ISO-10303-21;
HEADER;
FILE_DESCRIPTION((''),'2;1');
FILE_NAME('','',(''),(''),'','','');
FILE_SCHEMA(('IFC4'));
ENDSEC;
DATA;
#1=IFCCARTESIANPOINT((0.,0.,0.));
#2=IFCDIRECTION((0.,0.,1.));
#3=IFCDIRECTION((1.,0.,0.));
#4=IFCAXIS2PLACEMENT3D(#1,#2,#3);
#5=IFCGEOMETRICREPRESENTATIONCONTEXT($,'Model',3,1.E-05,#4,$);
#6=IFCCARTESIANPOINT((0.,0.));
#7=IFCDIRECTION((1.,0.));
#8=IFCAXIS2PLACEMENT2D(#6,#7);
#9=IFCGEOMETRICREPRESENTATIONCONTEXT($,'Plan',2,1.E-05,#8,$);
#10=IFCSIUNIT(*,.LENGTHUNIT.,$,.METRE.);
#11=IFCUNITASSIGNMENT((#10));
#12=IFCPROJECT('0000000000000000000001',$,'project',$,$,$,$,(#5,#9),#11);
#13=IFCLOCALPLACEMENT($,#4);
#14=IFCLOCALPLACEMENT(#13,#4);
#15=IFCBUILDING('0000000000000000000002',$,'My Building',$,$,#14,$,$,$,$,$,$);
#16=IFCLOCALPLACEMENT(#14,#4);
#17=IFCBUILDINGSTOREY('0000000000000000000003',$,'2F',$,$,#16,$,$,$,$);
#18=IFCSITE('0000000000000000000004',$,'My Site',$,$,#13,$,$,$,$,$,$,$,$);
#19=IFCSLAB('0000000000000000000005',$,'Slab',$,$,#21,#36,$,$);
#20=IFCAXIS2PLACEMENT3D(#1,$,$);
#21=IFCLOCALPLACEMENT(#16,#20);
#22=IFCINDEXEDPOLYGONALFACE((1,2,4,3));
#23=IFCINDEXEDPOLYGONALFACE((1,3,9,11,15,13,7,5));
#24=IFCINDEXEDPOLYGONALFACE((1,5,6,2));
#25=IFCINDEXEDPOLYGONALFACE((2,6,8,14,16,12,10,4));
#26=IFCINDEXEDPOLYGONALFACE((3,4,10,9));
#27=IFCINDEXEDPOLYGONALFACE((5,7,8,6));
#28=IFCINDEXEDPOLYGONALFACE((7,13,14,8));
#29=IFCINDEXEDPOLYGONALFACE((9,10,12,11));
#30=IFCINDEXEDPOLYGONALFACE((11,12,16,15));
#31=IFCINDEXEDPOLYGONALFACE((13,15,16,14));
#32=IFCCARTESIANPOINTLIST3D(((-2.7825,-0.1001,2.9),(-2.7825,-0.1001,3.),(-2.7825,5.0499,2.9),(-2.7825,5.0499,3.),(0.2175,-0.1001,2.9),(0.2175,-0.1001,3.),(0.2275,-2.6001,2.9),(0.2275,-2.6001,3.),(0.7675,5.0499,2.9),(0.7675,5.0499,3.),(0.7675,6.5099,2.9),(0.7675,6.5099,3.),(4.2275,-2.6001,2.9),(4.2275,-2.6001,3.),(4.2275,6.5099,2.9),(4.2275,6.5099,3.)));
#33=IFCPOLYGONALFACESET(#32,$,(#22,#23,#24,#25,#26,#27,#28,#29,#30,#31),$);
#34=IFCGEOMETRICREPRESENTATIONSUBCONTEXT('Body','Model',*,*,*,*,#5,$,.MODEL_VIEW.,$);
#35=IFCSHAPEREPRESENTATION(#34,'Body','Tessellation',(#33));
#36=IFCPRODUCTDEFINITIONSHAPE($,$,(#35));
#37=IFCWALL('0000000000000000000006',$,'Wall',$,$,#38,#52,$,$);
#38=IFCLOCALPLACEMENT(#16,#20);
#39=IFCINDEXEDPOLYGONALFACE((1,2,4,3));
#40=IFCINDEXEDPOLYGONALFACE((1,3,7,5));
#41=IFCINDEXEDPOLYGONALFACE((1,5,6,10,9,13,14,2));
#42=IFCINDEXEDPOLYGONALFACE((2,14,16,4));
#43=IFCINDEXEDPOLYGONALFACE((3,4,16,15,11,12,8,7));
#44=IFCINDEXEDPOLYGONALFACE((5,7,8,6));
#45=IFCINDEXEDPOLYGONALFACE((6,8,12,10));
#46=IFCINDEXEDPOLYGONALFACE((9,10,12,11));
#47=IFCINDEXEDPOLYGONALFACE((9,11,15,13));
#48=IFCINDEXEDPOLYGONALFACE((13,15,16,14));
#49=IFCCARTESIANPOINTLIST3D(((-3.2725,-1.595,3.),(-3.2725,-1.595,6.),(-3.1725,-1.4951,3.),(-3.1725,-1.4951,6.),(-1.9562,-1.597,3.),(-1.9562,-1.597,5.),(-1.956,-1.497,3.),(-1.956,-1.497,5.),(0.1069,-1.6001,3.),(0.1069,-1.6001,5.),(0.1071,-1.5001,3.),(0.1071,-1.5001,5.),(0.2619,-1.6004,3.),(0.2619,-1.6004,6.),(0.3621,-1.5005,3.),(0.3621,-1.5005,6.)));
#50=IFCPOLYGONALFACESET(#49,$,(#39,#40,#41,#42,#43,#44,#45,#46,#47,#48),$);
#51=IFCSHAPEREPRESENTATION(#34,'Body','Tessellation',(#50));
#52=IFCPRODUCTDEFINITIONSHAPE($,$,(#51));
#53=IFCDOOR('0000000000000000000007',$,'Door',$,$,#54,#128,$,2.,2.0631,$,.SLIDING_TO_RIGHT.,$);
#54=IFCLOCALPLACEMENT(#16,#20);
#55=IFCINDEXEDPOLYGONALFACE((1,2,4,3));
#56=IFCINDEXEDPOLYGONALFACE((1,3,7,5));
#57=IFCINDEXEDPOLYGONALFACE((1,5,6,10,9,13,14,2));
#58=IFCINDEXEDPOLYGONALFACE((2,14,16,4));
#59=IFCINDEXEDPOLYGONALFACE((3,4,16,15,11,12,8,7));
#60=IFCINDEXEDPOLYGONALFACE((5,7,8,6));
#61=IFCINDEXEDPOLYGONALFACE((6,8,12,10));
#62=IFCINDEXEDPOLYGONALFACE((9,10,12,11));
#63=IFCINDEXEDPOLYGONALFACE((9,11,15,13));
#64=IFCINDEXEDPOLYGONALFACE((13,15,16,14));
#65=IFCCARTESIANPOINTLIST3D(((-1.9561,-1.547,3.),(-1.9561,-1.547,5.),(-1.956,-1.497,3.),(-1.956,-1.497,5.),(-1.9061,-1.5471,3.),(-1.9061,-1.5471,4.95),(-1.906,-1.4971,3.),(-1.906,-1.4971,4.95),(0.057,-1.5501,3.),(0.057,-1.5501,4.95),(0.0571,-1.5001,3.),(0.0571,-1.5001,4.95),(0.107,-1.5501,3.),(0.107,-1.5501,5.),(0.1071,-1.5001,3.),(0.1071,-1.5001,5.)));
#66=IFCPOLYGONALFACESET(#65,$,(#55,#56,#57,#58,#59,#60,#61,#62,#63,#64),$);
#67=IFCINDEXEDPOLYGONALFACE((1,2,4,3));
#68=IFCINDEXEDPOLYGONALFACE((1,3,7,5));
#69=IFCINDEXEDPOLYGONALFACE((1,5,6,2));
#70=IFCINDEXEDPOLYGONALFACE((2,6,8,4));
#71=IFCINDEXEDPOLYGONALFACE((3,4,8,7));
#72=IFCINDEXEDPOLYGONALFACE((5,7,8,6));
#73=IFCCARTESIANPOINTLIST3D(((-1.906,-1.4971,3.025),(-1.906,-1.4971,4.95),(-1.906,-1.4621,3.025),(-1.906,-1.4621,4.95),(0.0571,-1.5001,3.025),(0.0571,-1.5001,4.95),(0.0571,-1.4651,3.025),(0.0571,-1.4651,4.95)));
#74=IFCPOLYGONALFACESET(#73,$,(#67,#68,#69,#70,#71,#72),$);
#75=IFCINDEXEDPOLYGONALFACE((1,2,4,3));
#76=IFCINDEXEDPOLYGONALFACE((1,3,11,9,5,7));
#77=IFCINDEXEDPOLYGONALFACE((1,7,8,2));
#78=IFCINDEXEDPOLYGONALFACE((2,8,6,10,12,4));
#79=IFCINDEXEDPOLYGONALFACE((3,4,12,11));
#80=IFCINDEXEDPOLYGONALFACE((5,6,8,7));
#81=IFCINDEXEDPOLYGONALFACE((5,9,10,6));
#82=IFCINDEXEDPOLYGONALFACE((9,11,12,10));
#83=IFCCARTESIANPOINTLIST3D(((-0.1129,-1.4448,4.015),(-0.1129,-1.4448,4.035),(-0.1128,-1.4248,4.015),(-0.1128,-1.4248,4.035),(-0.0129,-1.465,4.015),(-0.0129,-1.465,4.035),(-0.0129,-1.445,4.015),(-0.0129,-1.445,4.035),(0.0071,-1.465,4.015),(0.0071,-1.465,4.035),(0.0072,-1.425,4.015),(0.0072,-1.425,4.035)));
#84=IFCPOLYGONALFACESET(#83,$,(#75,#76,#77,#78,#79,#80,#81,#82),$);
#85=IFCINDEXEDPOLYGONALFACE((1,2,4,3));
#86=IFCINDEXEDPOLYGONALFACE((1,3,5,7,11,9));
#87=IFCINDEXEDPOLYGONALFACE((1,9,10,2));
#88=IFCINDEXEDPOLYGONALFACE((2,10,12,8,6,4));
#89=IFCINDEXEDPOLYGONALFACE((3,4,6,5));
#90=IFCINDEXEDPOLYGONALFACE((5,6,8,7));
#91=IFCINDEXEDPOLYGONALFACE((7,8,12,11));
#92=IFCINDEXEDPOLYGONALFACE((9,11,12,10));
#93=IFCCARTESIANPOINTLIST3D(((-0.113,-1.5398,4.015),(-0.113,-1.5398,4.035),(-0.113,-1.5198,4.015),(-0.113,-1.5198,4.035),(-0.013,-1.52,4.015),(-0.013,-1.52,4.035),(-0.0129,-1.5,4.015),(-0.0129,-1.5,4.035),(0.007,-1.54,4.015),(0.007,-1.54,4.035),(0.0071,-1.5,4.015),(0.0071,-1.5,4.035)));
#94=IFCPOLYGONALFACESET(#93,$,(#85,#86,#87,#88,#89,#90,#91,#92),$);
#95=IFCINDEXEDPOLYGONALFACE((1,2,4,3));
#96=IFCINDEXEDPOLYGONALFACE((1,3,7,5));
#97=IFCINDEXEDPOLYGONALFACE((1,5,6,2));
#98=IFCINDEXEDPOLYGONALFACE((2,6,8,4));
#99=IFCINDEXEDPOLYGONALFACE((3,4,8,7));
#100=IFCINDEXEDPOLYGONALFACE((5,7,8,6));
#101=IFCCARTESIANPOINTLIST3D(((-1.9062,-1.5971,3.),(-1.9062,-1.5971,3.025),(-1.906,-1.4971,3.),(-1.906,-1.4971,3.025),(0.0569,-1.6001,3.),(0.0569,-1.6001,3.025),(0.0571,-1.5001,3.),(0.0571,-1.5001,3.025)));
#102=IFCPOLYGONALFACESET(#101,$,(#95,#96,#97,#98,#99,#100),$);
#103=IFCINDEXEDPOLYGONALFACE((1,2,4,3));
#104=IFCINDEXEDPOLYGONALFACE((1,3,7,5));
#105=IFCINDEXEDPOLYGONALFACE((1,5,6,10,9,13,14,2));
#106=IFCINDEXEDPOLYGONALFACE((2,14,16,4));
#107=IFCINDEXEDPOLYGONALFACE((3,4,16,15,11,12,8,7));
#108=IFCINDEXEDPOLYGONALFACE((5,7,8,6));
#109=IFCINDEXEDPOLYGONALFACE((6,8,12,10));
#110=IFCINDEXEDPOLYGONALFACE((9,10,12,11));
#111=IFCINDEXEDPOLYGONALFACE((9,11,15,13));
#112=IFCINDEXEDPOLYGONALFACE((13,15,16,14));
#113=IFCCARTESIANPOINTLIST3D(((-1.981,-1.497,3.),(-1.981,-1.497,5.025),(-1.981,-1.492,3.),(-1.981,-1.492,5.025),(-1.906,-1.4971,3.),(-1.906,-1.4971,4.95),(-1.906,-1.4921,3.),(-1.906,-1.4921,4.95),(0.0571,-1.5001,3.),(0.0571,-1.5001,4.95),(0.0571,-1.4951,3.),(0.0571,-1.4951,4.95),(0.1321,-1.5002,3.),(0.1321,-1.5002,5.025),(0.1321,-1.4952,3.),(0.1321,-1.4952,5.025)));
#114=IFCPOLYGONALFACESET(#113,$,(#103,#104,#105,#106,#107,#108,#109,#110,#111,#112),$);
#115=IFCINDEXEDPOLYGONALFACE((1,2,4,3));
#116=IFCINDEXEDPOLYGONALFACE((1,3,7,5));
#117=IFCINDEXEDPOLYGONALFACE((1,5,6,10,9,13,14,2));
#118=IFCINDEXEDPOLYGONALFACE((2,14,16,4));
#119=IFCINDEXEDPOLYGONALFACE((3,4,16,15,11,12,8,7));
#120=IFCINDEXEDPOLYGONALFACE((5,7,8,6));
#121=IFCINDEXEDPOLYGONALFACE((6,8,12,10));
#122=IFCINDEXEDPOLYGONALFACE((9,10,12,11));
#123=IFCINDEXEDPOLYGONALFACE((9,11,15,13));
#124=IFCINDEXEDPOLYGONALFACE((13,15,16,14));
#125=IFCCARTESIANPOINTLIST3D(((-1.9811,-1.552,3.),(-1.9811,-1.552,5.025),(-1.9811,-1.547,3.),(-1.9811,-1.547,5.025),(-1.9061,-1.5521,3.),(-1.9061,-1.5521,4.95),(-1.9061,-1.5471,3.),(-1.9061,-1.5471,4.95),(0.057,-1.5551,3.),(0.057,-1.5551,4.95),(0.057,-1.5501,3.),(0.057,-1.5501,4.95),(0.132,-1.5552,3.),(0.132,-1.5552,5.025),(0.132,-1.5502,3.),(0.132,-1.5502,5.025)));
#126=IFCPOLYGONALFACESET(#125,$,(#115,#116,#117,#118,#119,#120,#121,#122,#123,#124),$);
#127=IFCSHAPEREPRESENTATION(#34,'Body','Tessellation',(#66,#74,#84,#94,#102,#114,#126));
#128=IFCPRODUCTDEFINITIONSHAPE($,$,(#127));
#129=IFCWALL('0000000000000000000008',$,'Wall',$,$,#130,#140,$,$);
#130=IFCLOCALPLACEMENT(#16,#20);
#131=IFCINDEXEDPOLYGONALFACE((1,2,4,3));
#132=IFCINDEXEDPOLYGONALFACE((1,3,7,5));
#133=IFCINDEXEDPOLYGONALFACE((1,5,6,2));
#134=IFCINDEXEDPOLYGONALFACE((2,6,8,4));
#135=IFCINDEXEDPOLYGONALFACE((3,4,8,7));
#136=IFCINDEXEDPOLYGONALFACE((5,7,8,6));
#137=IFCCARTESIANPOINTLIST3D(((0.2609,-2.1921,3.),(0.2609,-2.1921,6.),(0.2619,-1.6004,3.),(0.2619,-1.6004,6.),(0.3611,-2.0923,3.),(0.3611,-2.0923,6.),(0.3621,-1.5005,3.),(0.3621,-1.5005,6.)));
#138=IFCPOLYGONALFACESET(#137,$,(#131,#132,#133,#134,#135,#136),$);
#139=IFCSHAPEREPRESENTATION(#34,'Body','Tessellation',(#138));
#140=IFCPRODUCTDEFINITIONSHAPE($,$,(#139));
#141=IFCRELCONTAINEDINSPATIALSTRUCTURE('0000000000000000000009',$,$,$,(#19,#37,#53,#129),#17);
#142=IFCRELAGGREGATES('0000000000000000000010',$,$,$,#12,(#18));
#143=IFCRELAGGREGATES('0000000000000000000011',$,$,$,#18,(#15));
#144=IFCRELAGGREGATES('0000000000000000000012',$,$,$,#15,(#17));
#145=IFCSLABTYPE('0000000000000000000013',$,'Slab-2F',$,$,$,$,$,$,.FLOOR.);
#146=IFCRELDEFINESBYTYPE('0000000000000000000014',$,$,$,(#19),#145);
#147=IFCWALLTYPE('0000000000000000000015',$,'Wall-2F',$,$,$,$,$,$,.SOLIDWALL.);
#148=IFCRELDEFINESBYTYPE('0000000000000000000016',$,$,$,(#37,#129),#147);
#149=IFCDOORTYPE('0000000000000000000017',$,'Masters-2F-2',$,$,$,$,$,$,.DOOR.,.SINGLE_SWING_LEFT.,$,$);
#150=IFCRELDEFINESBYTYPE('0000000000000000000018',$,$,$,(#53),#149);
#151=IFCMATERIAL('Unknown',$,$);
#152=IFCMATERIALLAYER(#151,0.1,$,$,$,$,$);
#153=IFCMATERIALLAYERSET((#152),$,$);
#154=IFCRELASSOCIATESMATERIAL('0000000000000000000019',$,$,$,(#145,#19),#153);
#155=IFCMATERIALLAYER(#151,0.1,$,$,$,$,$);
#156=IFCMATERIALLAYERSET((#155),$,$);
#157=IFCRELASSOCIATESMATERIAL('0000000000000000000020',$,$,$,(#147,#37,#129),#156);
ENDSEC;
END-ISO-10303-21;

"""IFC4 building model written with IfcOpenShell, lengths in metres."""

from ifc_helpers import new_model, entity, si_unit, frame, origin_with_axes, origin_2d_with_axis, place, context, subcontext, project, spatial, line, indexed_curve, outline, extrude, shape, source, transform, mapped, material, layer, layer_set, layer_usage, type_object, type_shapes, element, fill, save


model = new_model("IFC4")

# Units and contexts
model_context = context("Model", 3, precision=1e-05, world=origin_with_axes())
plan_context = context("Plan", 2, precision=1e-05, world=origin_2d_with_axis())
body_context_1 = subcontext(model_context, "Body", "Model", "MODEL_VIEW")
body_context_2 = subcontext(plan_context, "Body", "Plan", "PLAN_VIEW")
ifc_project = project(units=[si_unit("LENGTHUNIT", "METRE")], contexts=[model_context, plan_context])

# Site, building, storey
site_placement = place(None, origin_with_axes())
site = spatial("IfcSite", under=ifc_project, at=site_placement, Name="My Site")
building_placement = place(site_placement, origin_with_axes())
building = spatial("IfcBuilding", under=site, at=building_placement, Name="My Building")
storey_placement = place(building_placement, origin_with_axes())
storey = spatial("IfcBuildingStorey", under=building, at=storey_placement, Name="2F")

# Slab
ifc_material = material(Name="Unknown")
ifc_layer_1 = layer(ifc_material, 0.1)
ifc_layer_set_1 = layer_set([ifc_layer_1])
ifc_layer_usage_1 = layer_usage(ifc_layer_set_1, "AXIS3", "POSITIVE", -0.1)
slab_type = type_object("IfcSlabType", Name="Slab-2F", PredefinedType="FLOOR", material=ifc_layer_set_1)
slab_placement = place(storey_placement, frame((4.2275, -2.6001, 3.0), z_axis=(0.0, 0.0, 1.0), x_axis=(1.0, 0.0, 0.0)))
element("IfcSlab", 1, at=slab_placement, inside=storey, type_object=slab_type, material=ifc_layer_usage_1, Name="Slab", context=body_context_1, shape_type="SweptSolid", body=[
    extrude(outline(indexed_curve([(0.0, 0.0), (0.0, 9.11), (-3.46, 9.11), (-3.46, 7.65), (-7.01, 7.65), (-7.01, 2.5), (-4.01, 2.5), (-4.0, 0.0), (0.0, 0.0)])), frame((0.0, 0.0, -0.1), z_axis=(0.0, 0.0, 1.0), x_axis=(1.0, 0.0, 0.0)), (0.0, 0.0, 1.0), 0.1),
])

# Wall, opening, door
ifc_layer_2 = layer(ifc_material, 0.1)
ifc_layer_set_2 = layer_set([ifc_layer_2])
ifc_layer_usage_2 = layer_usage(ifc_layer_set_2, "AXIS2", "POSITIVE", 0.0)
wall_type = type_object("IfcWallType", Name="Wall-2F", PredefinedType="SOLIDWALL", material=ifc_layer_set_2)
wall_1_placement = place(storey_placement, frame((-3.2725, -1.595, 3.0), z_axis=(0.0, 0.0, 1.0), x_axis=(0.999999, -0.001525, 0.0)))
wall_1 = element("IfcWall", 2, at=wall_1_placement, inside=storey, type_object=wall_type, material=ifc_layer_usage_2, Name="Wall", context=body_context_1, shape_type="SweptSolid", body=[
    extrude(outline(indexed_curve([(0.0, 0.0), (0.0998, 0.1), (3.6345, 0.1), (3.5345, 0.0)], segments=[line(1, 2, 3, 4, 1)])), origin_with_axes(), (0.0, 0.0, 1.0), 3.0),
])
shared_shape_1 = source(origin_with_axes(), body_context_1, "Body", "SweptSolid", [
    extrude(outline(indexed_curve([(0.0, 0.0), (2.0631, 0.0), (2.0631, 2.0), (0.0, 2.0)], segments=[line(1, 2, 3, 4, 1)])), frame((0.0, -0.6, 0.0), z_axis=(0.0, -1.0, 0.0), x_axis=(1.0, 0.0, 0.0)), (0.0, 0.0, -1.0), 1.2),
])
opening_1_placement = place(wall_1_placement, frame((3.3794, 0.1, 0.0), z_axis=(0.0, 0.0, 1.0), x_axis=(-1.0, 0.0, 0.0)))
opening_1 = element("IfcOpeningElement", 3, at=opening_1_placement, cuts=wall_1, PredefinedType="OPENING", context=body_context_1, shape_type="MappedRepresentation", body=[
    mapped(shared_shape_1, transform((0.0, 0.0, 0.0), x_axis=(1.0, 0.0, 0.0), y_axis=(0.0, 1.0, 0.0), z_axis=(0.0, 0.0, 1.0), scale=1.0)),
])
door_type_1 = type_object("IfcDoorType", Name="Masters-2F-2", OperationType="SINGLE_SWING_LEFT", PredefinedType="DOOR")
shared_shape_2 = source(origin_with_axes(), body_context_1, "Body", "SweptSolid", [
    extrude(outline(indexed_curve([(0.0, 0.0), (0.0, 2.0), (2.0631, 2.0), (2.0631, 0.0), (2.0131, 0.0), (2.0131, 1.95), (0.05, 1.95), (0.05, 0.0)], segments=[line(1, 2, 3, 4, 5, 6, 7, 8, 1)])), frame((0.0, 0.0, 0.0), z_axis=(0.0, -1.0, 0.0), x_axis=(1.0, 0.0, 0.0)), (0.0, 0.0, -1.0), 0.05),
    extrude(outline(indexed_curve([(0.0, 0.0), (1.9631, 0.0), (1.9631, 0.035), (0.0, 0.035)], segments=[line(1, 2, 3, 4, 1)])), frame((0.05, -0.035, 0.025), z_axis=(0.0, 0.0, 1.0), x_axis=(1.0, 0.0, 0.0)), (0.0, 0.0, 1.0), 1.925),
    extrude(outline(indexed_curve([(0.0, 0.0), (0.0, -0.04), (0.12, -0.04), (0.12, -0.02), (0.02, -0.02), (0.02, 0.0)], segments=[line(1, 2, 3, 4, 5, 6, 1)])), frame((0.1, -0.035, 1.015), z_axis=(0.0, 0.0, 1.0), x_axis=(1.0, 0.0, 0.0)), (0.0, 0.0, 1.0), 0.02),
    extrude(outline(indexed_curve([(0.0, 0.0), (0.0, 0.04), (0.12, 0.04), (0.12, 0.02), (0.02, 0.02), (0.02, 0.0)], segments=[line(1, 2, 3, 4, 5, 6, 1)])), frame((0.1, 0.0, 1.015), z_axis=(0.0, 0.0, 1.0), x_axis=(1.0, 0.0, 0.0)), (0.0, 0.0, 1.0), 0.02),
    extrude(outline(indexed_curve([(0.0, 0.0), (1.9631, 0.0), (1.9631, 0.1), (0.0, 0.1)], segments=[line(1, 2, 3, 4, 1)])), frame((0.05, 0.0, 0.0), z_axis=(0.0, 0.0, 1.0), x_axis=(1.0, 0.0, 0.0)), (0.0, 0.0, 1.0), 0.025),
    extrude(outline(indexed_curve([(0.0, 0.0), (0.0, 2.025), (2.1131, 2.025), (2.1131, 0.0), (2.0381, 0.0), (2.0381, 1.95), (0.075, 1.95), (0.075, 0.0)], segments=[line(1, 2, 3, 4, 5, 6, 7, 8, 1)])), frame((-0.025, -0.005, 0.0), z_axis=(0.0, -1.0, 0.0), x_axis=(1.0, 0.0, 0.0)), (0.0, 0.0, -1.0), 0.005),
    extrude(outline(indexed_curve([(0.0, 0.0), (0.0, 2.025), (2.1131, 2.025), (2.1131, 0.0), (2.0381, 0.0), (2.0381, 1.95), (0.075, 1.95), (0.075, 0.0)], segments=[line(1, 2, 3, 4, 5, 6, 7, 8, 1)])), frame((-0.025, 0.05, 0.0), z_axis=(0.0, -1.0, 0.0), x_axis=(1.0, 0.0, 0.0)), (0.0, 0.0, -1.0), 0.005),
])
shared_shape_3 = source(origin_with_axes(), body_context_2, "Body", "Curve2D", [
    entity("IfcIndexedPolyCurve", entity("IfcCartesianPointList2D", [[0.0, 0.0], [0.05, 0.0], [0.05, 0.05], [0.0, 0.05]]), [entity("IfcLineIndex", [1, 2, 3, 4, 1])]),
    entity("IfcIndexedPolyCurve", entity("IfcCartesianPointList2D", [[2.0631, 0.0], [2.0131, 0.0], [2.0131, 0.05], [2.0631, 0.05]]), [entity("IfcLineIndex", [1, 2, 3, 4, 1])]),
    entity("IfcIndexedPolyCurve", entity("IfcCartesianPointList2D", [[2.9946, -0.035], [1.0315, -0.035], [1.0315, 0.0], [2.9946, 0.0]]), [entity("IfcLineIndex", [1, 2, 3, 4, 1])]),
])
type_shapes(door_type_1, [shared_shape_2, shared_shape_3])
door_1_placement = place(opening_1_placement, frame((0.0, 0.0, 0.0), z_axis=(0.0, 0.0, 1.0), x_axis=(1.0, 0.0, 0.0)))
door_1 = element("IfcDoor", 4, at=door_1_placement, inside=storey, type_object=door_type_1, Name="Door", OperationType="SLIDING_TO_RIGHT", OverallHeight=2.0, OverallWidth=2.0631, shapes=[
    shape(body_context_1, "Body", "MappedRepresentation", [mapped(shared_shape_2, transform((0.0, 0.0, 0.0), x_axis=(1.0, 0.0, 0.0), y_axis=(0.0, 1.0, 0.0), z_axis=(0.0, 0.0, 1.0), scale=1.0))]),
    shape(body_context_2, "Body", "MappedRepresentation", [mapped(shared_shape_3, transform((0.0, 0.0, 0.0), x_axis=(1.0, 0.0, 0.0), y_axis=(0.0, 1.0, 0.0), z_axis=(0.0, 0.0, 1.0), scale=1.0))]),
])
fill(opening_1, door_1)

# Wall
ifc_layer_usage_3 = layer_usage(ifc_layer_set_2, "AXIS2", "POSITIVE", 0.0)
wall_2_placement = place(storey_placement, frame((0.2619, -1.6004, 3.0), z_axis=(0.0, 0.0, 1.0), x_axis=(-0.001703, -0.999999, 0.0)))
element("IfcWall", 5, at=wall_2_placement, inside=storey, type_object=wall_type, material=ifc_layer_usage_3, Name="Wall", context=body_context_1, shape_type="SweptSolid", body=[
    extrude(outline(indexed_curve([(0.0, 0.0), (-0.1, 0.1), (0.4917, 0.1), (0.5917, 0.0)], segments=[line(1, 2, 3, 4, 1)])), origin_with_axes(), (0.0, 0.0, 1.0), 3.0),
])

save(model, "model.ifc")
